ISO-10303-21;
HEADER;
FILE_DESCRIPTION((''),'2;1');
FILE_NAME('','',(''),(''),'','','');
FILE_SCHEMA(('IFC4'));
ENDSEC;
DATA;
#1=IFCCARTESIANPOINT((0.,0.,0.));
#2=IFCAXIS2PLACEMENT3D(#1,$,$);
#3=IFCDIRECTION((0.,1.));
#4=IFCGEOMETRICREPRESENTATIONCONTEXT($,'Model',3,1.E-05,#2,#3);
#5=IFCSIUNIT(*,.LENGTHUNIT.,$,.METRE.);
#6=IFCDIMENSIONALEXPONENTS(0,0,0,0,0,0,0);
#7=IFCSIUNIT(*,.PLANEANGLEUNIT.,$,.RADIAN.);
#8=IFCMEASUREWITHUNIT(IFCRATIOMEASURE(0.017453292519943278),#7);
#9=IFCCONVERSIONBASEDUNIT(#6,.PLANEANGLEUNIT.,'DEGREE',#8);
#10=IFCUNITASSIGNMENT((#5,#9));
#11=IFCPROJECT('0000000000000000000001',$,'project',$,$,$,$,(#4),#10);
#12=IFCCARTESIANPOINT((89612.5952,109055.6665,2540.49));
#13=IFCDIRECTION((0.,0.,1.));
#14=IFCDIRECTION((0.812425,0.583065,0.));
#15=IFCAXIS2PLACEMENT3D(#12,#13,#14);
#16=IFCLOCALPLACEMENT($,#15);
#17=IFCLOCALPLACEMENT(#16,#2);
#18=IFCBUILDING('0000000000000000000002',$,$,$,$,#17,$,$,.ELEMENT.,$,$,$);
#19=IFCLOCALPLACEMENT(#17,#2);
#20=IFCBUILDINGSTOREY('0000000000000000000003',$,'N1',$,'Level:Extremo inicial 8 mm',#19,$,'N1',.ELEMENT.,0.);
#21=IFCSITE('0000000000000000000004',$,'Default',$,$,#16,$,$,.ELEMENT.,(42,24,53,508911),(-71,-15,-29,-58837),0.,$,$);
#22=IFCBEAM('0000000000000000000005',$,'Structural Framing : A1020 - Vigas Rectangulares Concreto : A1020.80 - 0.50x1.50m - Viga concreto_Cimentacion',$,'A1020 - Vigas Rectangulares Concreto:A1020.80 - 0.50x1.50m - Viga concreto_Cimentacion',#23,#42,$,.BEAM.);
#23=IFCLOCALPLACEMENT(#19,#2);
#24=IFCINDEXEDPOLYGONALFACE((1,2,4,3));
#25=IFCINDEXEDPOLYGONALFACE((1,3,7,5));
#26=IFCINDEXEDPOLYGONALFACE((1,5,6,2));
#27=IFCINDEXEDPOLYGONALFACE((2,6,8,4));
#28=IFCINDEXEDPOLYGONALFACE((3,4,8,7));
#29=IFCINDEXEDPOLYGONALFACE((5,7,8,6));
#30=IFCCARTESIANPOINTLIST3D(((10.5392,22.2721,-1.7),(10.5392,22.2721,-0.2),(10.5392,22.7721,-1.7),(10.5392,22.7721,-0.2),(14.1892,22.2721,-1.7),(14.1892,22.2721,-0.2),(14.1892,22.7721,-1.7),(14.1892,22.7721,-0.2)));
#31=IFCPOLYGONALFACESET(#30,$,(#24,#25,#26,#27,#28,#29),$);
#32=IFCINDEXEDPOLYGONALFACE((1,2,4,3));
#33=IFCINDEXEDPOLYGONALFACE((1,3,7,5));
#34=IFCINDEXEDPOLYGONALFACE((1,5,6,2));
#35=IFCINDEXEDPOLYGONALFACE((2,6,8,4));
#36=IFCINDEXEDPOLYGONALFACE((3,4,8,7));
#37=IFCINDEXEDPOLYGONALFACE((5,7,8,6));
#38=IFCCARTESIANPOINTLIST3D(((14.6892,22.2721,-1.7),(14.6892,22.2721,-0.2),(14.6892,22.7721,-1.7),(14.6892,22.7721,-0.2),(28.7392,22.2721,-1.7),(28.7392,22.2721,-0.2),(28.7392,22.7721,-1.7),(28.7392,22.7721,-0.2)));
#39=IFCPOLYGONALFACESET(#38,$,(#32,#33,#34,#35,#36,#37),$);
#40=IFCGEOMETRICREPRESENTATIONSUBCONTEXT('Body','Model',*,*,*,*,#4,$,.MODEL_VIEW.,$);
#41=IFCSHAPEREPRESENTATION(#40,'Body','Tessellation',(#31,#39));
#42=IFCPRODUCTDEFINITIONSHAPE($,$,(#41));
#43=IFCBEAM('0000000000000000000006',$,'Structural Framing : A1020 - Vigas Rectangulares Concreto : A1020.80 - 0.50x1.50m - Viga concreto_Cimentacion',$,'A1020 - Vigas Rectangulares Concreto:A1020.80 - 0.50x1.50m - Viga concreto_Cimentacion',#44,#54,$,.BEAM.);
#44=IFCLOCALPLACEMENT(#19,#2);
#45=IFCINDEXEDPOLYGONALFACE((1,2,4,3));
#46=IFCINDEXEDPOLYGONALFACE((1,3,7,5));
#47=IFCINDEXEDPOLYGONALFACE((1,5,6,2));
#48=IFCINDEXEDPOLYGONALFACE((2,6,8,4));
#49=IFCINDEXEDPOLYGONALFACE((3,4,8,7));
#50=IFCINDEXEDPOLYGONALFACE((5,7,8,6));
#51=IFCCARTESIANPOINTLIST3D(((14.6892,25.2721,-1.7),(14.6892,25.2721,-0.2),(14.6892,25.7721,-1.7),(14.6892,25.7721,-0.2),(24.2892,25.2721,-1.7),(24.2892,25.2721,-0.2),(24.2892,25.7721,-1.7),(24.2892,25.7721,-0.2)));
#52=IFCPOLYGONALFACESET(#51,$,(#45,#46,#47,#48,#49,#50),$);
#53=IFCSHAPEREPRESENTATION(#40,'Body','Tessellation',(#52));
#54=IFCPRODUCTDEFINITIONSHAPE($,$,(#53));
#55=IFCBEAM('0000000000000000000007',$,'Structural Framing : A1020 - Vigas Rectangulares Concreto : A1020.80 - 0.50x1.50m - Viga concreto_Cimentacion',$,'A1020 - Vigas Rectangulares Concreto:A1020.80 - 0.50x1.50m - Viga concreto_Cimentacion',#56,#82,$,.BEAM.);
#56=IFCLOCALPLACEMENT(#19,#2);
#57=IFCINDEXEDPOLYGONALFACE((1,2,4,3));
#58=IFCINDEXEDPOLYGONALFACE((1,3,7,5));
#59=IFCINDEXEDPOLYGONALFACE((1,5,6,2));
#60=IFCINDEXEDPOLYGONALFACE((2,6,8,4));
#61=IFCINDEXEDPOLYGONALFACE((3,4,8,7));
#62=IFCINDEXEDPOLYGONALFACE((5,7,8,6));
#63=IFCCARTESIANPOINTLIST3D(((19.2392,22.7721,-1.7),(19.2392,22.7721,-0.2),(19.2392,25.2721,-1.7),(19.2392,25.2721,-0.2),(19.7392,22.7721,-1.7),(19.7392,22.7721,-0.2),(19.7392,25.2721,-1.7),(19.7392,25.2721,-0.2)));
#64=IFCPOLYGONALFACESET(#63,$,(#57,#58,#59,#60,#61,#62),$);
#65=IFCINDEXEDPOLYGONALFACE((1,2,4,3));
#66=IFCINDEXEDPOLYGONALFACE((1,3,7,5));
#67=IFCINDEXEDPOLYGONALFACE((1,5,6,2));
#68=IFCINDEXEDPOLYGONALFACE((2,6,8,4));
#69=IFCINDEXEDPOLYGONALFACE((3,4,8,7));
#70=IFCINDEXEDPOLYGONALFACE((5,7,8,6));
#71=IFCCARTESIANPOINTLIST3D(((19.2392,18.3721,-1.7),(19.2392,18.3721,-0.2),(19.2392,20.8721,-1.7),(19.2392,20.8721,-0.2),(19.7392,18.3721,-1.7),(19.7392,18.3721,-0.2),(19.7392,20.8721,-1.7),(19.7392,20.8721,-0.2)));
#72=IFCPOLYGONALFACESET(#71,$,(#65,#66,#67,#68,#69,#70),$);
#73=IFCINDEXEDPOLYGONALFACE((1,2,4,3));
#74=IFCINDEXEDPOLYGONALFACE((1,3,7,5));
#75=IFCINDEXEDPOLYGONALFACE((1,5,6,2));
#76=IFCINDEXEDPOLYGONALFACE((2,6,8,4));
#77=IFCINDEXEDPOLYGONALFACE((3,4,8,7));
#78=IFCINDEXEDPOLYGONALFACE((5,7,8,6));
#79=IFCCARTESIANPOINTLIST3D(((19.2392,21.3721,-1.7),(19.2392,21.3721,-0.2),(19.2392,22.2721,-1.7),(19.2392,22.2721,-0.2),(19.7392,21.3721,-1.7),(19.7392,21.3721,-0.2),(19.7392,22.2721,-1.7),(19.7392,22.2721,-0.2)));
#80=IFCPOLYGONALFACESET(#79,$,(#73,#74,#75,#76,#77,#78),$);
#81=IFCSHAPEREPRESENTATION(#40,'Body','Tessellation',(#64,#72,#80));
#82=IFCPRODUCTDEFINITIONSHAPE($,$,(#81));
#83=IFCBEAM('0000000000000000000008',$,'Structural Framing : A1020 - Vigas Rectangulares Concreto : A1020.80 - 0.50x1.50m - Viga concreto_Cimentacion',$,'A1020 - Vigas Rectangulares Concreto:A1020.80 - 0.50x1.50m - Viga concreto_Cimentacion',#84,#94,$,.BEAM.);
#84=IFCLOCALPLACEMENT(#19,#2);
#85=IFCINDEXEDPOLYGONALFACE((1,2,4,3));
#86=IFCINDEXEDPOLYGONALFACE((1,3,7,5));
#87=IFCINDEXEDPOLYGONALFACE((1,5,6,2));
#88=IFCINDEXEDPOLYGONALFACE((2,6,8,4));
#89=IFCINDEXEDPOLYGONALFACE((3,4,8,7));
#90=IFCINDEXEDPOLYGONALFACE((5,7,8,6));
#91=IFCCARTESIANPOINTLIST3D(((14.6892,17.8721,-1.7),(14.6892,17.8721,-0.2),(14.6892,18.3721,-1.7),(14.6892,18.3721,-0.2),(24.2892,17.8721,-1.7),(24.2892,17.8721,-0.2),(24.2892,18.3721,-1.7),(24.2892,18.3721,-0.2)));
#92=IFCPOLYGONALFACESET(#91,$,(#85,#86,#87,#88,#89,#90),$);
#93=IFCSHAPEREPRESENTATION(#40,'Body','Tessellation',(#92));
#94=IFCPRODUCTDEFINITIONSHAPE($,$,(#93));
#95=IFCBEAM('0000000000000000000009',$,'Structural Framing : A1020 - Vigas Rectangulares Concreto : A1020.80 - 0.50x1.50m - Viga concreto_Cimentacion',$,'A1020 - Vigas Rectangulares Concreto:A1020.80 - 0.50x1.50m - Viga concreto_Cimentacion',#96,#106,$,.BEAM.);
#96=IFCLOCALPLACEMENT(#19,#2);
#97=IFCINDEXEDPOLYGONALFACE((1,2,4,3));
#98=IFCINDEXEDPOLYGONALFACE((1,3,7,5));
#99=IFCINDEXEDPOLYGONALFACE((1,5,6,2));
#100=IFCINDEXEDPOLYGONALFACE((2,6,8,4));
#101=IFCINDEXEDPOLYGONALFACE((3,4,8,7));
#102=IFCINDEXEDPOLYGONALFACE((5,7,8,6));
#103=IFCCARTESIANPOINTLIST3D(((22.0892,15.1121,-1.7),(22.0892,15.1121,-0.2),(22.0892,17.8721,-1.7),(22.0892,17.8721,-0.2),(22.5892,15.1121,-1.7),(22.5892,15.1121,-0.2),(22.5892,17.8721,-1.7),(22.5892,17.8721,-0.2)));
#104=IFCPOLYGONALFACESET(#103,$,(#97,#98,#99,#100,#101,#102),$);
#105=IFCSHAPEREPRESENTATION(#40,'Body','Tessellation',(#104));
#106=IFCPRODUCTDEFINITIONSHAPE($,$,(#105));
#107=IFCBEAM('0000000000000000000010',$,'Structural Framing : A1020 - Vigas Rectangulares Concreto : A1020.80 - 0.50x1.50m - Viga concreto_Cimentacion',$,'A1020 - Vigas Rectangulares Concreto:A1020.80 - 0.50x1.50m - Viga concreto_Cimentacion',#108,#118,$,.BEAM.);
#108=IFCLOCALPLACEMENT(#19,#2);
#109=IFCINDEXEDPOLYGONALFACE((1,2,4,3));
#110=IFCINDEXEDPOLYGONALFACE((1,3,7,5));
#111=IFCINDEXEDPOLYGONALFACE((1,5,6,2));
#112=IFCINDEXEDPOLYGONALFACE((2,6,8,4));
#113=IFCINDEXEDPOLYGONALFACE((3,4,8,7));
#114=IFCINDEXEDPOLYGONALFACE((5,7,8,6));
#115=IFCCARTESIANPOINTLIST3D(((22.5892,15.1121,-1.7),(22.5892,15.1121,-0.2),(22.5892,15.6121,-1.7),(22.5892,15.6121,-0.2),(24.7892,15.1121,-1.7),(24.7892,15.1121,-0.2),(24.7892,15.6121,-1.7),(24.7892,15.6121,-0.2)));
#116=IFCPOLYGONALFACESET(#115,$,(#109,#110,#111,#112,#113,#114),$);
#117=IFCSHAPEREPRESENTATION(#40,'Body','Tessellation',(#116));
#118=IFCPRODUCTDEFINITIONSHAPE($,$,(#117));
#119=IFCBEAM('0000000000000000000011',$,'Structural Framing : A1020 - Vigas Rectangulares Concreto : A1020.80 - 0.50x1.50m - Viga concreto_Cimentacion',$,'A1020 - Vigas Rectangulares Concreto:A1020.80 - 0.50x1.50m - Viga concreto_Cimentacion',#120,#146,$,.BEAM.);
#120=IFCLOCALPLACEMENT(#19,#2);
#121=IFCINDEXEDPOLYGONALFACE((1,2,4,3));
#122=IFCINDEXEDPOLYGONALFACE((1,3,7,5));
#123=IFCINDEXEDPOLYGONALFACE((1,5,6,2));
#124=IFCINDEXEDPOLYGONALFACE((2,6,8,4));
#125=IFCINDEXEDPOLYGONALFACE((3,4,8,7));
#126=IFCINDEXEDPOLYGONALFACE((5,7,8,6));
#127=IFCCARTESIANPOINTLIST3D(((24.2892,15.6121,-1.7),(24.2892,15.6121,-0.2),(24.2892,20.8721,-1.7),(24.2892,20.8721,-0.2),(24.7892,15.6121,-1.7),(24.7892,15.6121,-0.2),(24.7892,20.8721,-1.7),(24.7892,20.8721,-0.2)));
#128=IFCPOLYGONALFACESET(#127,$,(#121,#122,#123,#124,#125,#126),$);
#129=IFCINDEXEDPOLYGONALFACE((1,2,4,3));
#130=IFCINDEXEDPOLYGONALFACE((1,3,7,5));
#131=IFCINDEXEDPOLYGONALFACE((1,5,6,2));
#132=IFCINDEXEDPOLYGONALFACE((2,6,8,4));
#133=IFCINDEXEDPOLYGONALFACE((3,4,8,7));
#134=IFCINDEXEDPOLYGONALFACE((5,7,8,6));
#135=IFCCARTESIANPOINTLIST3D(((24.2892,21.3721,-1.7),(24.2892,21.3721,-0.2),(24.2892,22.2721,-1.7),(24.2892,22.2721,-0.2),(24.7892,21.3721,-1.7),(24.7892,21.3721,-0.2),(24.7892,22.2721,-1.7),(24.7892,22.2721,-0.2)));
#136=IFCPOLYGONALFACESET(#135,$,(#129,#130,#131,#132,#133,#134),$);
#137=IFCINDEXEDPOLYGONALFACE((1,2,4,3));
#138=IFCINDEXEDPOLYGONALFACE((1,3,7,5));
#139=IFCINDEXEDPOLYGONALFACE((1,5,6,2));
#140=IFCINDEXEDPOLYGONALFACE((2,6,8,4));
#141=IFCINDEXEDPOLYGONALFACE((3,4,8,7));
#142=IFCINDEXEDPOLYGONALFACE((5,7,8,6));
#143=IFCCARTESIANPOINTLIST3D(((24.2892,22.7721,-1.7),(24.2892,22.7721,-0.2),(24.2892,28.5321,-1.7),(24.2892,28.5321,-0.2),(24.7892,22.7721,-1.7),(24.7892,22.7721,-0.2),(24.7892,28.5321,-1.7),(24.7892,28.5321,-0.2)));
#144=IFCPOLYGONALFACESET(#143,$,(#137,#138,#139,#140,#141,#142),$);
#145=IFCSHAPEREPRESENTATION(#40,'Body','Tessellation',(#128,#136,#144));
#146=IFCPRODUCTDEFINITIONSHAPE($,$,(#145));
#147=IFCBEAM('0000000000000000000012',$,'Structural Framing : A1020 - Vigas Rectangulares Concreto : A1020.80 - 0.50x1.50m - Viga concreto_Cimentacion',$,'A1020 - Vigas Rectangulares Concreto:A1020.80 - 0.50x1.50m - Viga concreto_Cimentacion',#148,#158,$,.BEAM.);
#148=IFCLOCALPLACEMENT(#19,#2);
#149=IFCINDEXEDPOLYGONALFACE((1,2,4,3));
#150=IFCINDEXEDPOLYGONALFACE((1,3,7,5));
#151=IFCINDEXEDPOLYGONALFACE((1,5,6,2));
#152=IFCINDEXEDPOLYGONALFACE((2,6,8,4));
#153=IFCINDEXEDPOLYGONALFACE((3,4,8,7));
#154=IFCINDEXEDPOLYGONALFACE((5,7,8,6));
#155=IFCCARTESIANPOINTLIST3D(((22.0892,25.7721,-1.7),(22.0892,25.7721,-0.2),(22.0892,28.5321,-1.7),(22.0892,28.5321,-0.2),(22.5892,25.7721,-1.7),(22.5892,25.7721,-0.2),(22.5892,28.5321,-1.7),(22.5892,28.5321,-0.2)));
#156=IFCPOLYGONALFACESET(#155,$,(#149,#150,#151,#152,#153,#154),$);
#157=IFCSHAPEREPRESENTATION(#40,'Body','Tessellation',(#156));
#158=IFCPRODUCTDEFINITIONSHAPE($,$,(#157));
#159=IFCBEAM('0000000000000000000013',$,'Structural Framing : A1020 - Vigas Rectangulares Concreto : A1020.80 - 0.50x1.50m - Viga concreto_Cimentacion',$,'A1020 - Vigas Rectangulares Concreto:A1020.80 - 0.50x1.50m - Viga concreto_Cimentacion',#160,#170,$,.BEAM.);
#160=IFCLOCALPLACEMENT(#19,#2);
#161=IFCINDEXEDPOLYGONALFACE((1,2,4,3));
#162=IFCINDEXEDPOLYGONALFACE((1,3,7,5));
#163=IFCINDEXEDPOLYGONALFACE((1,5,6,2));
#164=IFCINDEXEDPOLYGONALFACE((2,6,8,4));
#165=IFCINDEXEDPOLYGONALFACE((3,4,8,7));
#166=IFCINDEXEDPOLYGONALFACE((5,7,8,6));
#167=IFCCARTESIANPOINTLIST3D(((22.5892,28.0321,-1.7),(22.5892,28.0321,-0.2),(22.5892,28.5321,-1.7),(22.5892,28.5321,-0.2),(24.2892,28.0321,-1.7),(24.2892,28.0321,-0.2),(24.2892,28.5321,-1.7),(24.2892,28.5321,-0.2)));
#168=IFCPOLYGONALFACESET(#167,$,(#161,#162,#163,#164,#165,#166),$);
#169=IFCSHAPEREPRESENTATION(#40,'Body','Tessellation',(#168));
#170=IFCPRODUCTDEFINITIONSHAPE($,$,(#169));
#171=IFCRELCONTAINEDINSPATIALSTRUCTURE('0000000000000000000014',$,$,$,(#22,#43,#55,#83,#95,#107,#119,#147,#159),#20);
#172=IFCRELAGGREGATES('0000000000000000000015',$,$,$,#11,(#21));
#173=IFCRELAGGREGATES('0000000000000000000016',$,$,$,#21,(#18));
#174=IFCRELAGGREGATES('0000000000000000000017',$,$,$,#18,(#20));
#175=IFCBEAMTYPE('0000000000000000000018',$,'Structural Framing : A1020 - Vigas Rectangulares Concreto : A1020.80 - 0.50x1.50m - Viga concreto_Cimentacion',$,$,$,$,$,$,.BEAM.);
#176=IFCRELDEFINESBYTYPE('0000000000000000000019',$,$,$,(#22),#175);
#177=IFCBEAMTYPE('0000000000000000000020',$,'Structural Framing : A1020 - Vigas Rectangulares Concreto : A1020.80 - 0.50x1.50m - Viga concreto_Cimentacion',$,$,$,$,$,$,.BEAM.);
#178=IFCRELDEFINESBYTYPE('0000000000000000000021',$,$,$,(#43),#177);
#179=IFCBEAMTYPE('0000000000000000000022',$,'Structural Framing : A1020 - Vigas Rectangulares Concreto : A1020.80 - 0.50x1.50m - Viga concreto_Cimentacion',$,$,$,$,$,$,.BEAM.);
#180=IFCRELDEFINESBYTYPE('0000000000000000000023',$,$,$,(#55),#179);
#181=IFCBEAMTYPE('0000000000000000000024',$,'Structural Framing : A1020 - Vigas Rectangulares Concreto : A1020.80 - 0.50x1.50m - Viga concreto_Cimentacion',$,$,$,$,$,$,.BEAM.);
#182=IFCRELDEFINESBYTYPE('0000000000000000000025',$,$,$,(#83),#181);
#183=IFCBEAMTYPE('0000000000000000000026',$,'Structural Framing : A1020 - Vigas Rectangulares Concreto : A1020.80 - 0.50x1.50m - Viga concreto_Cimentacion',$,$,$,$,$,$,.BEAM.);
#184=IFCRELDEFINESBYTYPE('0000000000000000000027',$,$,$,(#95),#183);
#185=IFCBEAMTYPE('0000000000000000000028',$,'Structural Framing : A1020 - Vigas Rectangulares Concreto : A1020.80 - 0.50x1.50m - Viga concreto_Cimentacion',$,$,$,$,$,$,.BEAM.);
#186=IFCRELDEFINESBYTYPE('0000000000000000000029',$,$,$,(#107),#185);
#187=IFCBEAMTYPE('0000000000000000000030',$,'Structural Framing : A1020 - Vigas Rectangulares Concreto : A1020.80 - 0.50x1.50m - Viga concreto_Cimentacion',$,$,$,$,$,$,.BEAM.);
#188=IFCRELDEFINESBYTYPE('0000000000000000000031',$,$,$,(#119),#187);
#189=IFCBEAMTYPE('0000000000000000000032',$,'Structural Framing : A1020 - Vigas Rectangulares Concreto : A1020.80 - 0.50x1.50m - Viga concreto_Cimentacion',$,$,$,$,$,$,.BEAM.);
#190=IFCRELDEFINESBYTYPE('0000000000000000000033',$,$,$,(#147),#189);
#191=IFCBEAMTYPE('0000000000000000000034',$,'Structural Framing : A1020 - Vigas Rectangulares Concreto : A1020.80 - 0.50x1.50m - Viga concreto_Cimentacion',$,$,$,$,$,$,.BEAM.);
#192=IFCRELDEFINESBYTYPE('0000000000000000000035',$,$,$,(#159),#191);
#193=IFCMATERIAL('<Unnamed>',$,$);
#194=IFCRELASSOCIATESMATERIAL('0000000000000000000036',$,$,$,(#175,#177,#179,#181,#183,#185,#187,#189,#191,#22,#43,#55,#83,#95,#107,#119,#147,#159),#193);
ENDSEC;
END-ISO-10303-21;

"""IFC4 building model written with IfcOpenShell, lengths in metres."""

from ifc_helpers import new_model, entity, si_unit, converted_unit, direction, frame, frame_2d, origin, place, context, subcontext, project, spatial, polyline, segment, composite_curve, rectangle, outline, extrude, source, transform, mapped, material, material_profile, profile_set, profile_usage, type_object, type_shapes, element, save


model = new_model("IFC4")

# Units and contexts
model_context = context("Model", 3, precision=1e-05, world=origin(), true_north=direction((0.0, 1.0)))
body_context = subcontext(model_context, "Body", "Model", "MODEL_VIEW")
ifc_project = project(units=[si_unit("LENGTHUNIT", "METRE"), converted_unit("PLANEANGLEUNIT", "DEGREE", entity("IfcRatioMeasure", 0.017453292519943278), si_unit("PLANEANGLEUNIT", "RADIAN"), dimensions=[0, 0, 0, 0, 0, 0, 0])], contexts=[model_context])

# Site, building, storey
site_placement = place(None, frame((89612.5952, 109055.6665, 2540.49), z_axis=(0.0, 0.0, 1.0), x_axis=(0.812425, 0.583065, 0.0)))
site = spatial("IfcSite", under=ifc_project, at=site_placement, Name="Default", CompositionType="ELEMENT", RefLatitude=(42, 24, 53, 508911), RefLongitude=(-71, -15, -29, -58837), RefElevation=0.0)
building_placement = place(site_placement, origin())
building = spatial("IfcBuilding", under=site, at=building_placement, CompositionType="ELEMENT")
storey_placement = place(building_placement, origin())
storey = spatial("IfcBuildingStorey", under=building, at=storey_placement, Name="N1", ObjectType="Level:Extremo inicial 8 mm", LongName="N1", CompositionType="ELEMENT", Elevation=0.0)

# Beams
ifc_material_1 = material(Name="<Unnamed>")
ifc_material_profile_1 = material_profile(ifc_material_1, outline(composite_curve([segment(polyline([(-0.25, -0.75, 0.0), (-0.25, 0.75, 0.0)]), True, "CONTINUOUS"), segment(polyline([(-0.25, 0.75, 0.0), (0.25, 0.75, 0.0)]), True, "CONTINUOUS"), segment(polyline([(0.25, 0.75, 0.0), (0.25, -0.75, 0.0)]), True, "CONTINUOUS"), segment(polyline([(0.25, -0.75, 0.0), (-0.25, -0.75, 0.0)]), True, "CONTINUOUS")], self_intersect=False), kind="CURVE"), Name="A1020.80 - 0.50x1.50m - Viga concreto_Cimentacion")
ifc_material_profile_2 = material_profile(ifc_material_1, outline(composite_curve([segment(polyline([(6.1973, 0.25, 0.75), (6.1973, 0.25, -0.75)]), True, "CONTINUOUS"), segment(polyline([(6.1973, 0.25, -0.75), (-6.1973, 0.25, -0.75)]), True, "CONTINUOUS"), segment(polyline([(-6.1973, 0.25, -0.75), (-6.1973, 0.25, 0.75)]), True, "CONTINUOUS"), segment(polyline([(-6.1973, 0.25, 0.75), (6.1973, 0.25, 0.75)]), True, "CONTINUOUS")], self_intersect=False), kind="CURVE"), Name="A1020.80 - 0.50x1.50m - Viga concreto_Cimentacion")
ifc_profile_set_1 = profile_set([ifc_material_profile_1, ifc_material_profile_2], Name="A1020.80 - 0.50x1.50m - Viga concreto_Cimentacion")
ifc_profile_usage_1 = profile_usage(ifc_profile_set_1, cardinal=8)
beam_type_1 = type_object("IfcBeamType", Name="Structural Framing : A1020 - Vigas Rectangulares Concreto : A1020.80 - 0.50x1.50m - Viga concreto_Cimentacion", PredefinedType="BEAM", material=ifc_profile_set_1)
shared_shape_1 = source(origin(), body_context, "Body", "SweptSolid", [
    extrude(rectangle(XDim=1.5, YDim=0.5, at=frame_2d((0.0, 0.0), x_axis=(1.0, 0.0))), frame((10.5392, 22.5221, -0.95), z_axis=(1.0, 0.0, 0.0), x_axis=(0.0, 0.0, -1.0)), (0.0, 0.0, 1.0), 3.65),
    extrude(rectangle(XDim=1.5, YDim=0.5, at=frame_2d((0.0, 0.0), x_axis=(1.0, 0.0))), frame((14.6892, 22.5221, -0.95), z_axis=(1.0, 0.0, 0.0), x_axis=(0.0, 0.0, -1.0)), (0.0, 0.0, 1.0), 14.05),
])
type_shapes(beam_type_1, [shared_shape_1])
beam_1_placement = place(storey_placement, origin())
element("IfcBeam", 1, at=beam_1_placement, inside=storey, type_object=beam_type_1, material=ifc_profile_usage_1, Name="Structural Framing : A1020 - Vigas Rectangulares Concreto : A1020.80 - 0.50x1.50m - Viga concreto_Cimentacion", ObjectType="A1020 - Vigas Rectangulares Concreto:A1020.80 - 0.50x1.50m - Viga concreto_Cimentacion", PredefinedType="BEAM", context=body_context, shape_type="MappedRepresentation", body=[
    mapped(shared_shape_1, transform((0.0, 0.0, 0.0), scale=1.0)),
])
ifc_profile_usage_2 = profile_usage(ifc_profile_set_1, cardinal=8)
beam_type_2 = type_object("IfcBeamType", Name="Structural Framing : A1020 - Vigas Rectangulares Concreto : A1020.80 - 0.50x1.50m - Viga concreto_Cimentacion", PredefinedType="BEAM", material=ifc_profile_set_1)
shared_shape_2 = source(origin(), body_context, "Body", "SweptSolid", [
    extrude(rectangle(XDim=1.5, YDim=0.5, at=frame_2d((0.0, 0.0), x_axis=(1.0, 0.0))), frame((14.6892, 25.5221, -0.95), z_axis=(1.0, 0.0, 0.0), x_axis=(0.0, 0.0, -1.0)), (0.0, 0.0, 1.0), 9.6),
])
type_shapes(beam_type_2, [shared_shape_2])
beam_2_placement = place(storey_placement, origin())
element("IfcBeam", 2, at=beam_2_placement, inside=storey, type_object=beam_type_2, material=ifc_profile_usage_2, Name="Structural Framing : A1020 - Vigas Rectangulares Concreto : A1020.80 - 0.50x1.50m - Viga concreto_Cimentacion", ObjectType="A1020 - Vigas Rectangulares Concreto:A1020.80 - 0.50x1.50m - Viga concreto_Cimentacion", PredefinedType="BEAM", context=body_context, shape_type="MappedRepresentation", body=[
    mapped(shared_shape_2, transform((0.0, 0.0, 0.0), scale=1.0)),
])
ifc_profile_usage_3 = profile_usage(ifc_profile_set_1, cardinal=8)
beam_type_3 = type_object("IfcBeamType", Name="Structural Framing : A1020 - Vigas Rectangulares Concreto : A1020.80 - 0.50x1.50m - Viga concreto_Cimentacion", PredefinedType="BEAM", material=ifc_profile_set_1)
shared_shape_3 = source(origin(), body_context, "Body", "SweptSolid", [
    extrude(rectangle(XDim=1.5, YDim=0.5, at=frame_2d((0.0, 0.0), x_axis=(0.0, 1.0))), frame((19.4892, 25.2721, -0.95), z_axis=(0.0, -1.0, 0.0), x_axis=(-1.0, 0.0, 0.0)), (0.0, 0.0, 1.0), 2.5),
    extrude(rectangle(XDim=1.5, YDim=0.5, at=frame_2d((0.0, 0.0), x_axis=(0.0, 1.0))), frame((19.4892, 20.8721, -0.95), z_axis=(0.0, -1.0, 0.0), x_axis=(-1.0, 0.0, 0.0)), (0.0, 0.0, 1.0), 2.5),
    extrude(rectangle(XDim=1.5, YDim=0.5, at=frame_2d((0.0, 0.0), x_axis=(0.0, 1.0))), frame((19.4892, 22.2721, -0.95), z_axis=(0.0, -1.0, 0.0), x_axis=(-1.0, 0.0, 0.0)), (0.0, 0.0, 1.0), 0.9),
])
type_shapes(beam_type_3, [shared_shape_3])
beam_3_placement = place(storey_placement, origin())
element("IfcBeam", 3, at=beam_3_placement, inside=storey, type_object=beam_type_3, material=ifc_profile_usage_3, Name="Structural Framing : A1020 - Vigas Rectangulares Concreto : A1020.80 - 0.50x1.50m - Viga concreto_Cimentacion", ObjectType="A1020 - Vigas Rectangulares Concreto:A1020.80 - 0.50x1.50m - Viga concreto_Cimentacion", PredefinedType="BEAM", context=body_context, shape_type="MappedRepresentation", body=[
    mapped(shared_shape_3, transform((0.0, 0.0, 0.0), scale=1.0)),
])
ifc_profile_usage_4 = profile_usage(ifc_profile_set_1, cardinal=8)
beam_type_4 = type_object("IfcBeamType", Name="Structural Framing : A1020 - Vigas Rectangulares Concreto : A1020.80 - 0.50x1.50m - Viga concreto_Cimentacion", PredefinedType="BEAM", material=ifc_profile_set_1)
shared_shape_4 = source(origin(), body_context, "Body", "SweptSolid", [
    extrude(rectangle(XDim=1.5, YDim=0.5, at=frame_2d((0.0, 0.0), x_axis=(1.0, 0.0))), frame((14.6892, 18.1221, -0.95), z_axis=(1.0, 0.0, 0.0), x_axis=(0.0, 0.0, -1.0)), (0.0, 0.0, 1.0), 9.6),
])
type_shapes(beam_type_4, [shared_shape_4])
beam_4_placement = place(storey_placement, origin())
element("IfcBeam", 4, at=beam_4_placement, inside=storey, type_object=beam_type_4, material=ifc_profile_usage_4, Name="Structural Framing : A1020 - Vigas Rectangulares Concreto : A1020.80 - 0.50x1.50m - Viga concreto_Cimentacion", ObjectType="A1020 - Vigas Rectangulares Concreto:A1020.80 - 0.50x1.50m - Viga concreto_Cimentacion", PredefinedType="BEAM", context=body_context, shape_type="MappedRepresentation", body=[
    mapped(shared_shape_4, transform((0.0, 0.0, 0.0), scale=1.0)),
])
ifc_profile_usage_5 = profile_usage(ifc_profile_set_1, cardinal=8)
beam_type_5 = type_object("IfcBeamType", Name="Structural Framing : A1020 - Vigas Rectangulares Concreto : A1020.80 - 0.50x1.50m - Viga concreto_Cimentacion", PredefinedType="BEAM", material=ifc_profile_set_1)
shared_shape_5 = source(origin(), body_context, "Body", "SweptSolid", [
    extrude(rectangle(XDim=1.5, YDim=0.5, at=frame_2d((0.0, 0.0), x_axis=(0.0, 1.0))), frame((22.3392, 17.8721, -0.95), z_axis=(0.0, -1.0, 0.0), x_axis=(-1.0, 0.0, 0.0)), (0.0, 0.0, 1.0), 2.76),
])
type_shapes(beam_type_5, [shared_shape_5])
beam_5_placement = place(storey_placement, origin())
element("IfcBeam", 5, at=beam_5_placement, inside=storey, type_object=beam_type_5, material=ifc_profile_usage_5, Name="Structural Framing : A1020 - Vigas Rectangulares Concreto : A1020.80 - 0.50x1.50m - Viga concreto_Cimentacion", ObjectType="A1020 - Vigas Rectangulares Concreto:A1020.80 - 0.50x1.50m - Viga concreto_Cimentacion", PredefinedType="BEAM", context=body_context, shape_type="MappedRepresentation", body=[
    mapped(shared_shape_5, transform((0.0, 0.0, 0.0), scale=1.0)),
])
ifc_profile_usage_6 = profile_usage(ifc_profile_set_1, cardinal=8)
beam_type_6 = type_object("IfcBeamType", Name="Structural Framing : A1020 - Vigas Rectangulares Concreto : A1020.80 - 0.50x1.50m - Viga concreto_Cimentacion", PredefinedType="BEAM", material=ifc_profile_set_1)
shared_shape_6 = source(origin(), body_context, "Body", "SweptSolid", [
    extrude(rectangle(XDim=1.5, YDim=0.5, at=frame_2d((0.0, 0.0), x_axis=(1.0, 0.0))), frame((22.5892, 15.3621, -0.95), z_axis=(1.0, 0.0, 0.0), x_axis=(0.0, 0.0, -1.0)), (0.0, 0.0, 1.0), 2.2),
])
type_shapes(beam_type_6, [shared_shape_6])
beam_6_placement = place(storey_placement, origin())
element("IfcBeam", 6, at=beam_6_placement, inside=storey, type_object=beam_type_6, material=ifc_profile_usage_6, Name="Structural Framing : A1020 - Vigas Rectangulares Concreto : A1020.80 - 0.50x1.50m - Viga concreto_Cimentacion", ObjectType="A1020 - Vigas Rectangulares Concreto:A1020.80 - 0.50x1.50m - Viga concreto_Cimentacion", PredefinedType="BEAM", context=body_context, shape_type="MappedRepresentation", body=[
    mapped(shared_shape_6, transform((0.0, 0.0, 0.0), scale=1.0)),
])
ifc_profile_usage_7 = profile_usage(ifc_profile_set_1, cardinal=8)
beam_type_7 = type_object("IfcBeamType", Name="Structural Framing : A1020 - Vigas Rectangulares Concreto : A1020.80 - 0.50x1.50m - Viga concreto_Cimentacion", PredefinedType="BEAM", material=ifc_profile_set_1)
shared_shape_7 = source(origin(), body_context, "Body", "SweptSolid", [
    extrude(rectangle(XDim=1.5, YDim=0.5, at=frame_2d((0.0, 0.0), x_axis=(0.0, 1.0))), frame((24.5392, 15.6121, -0.95), z_axis=(0.0, 1.0, 0.0), x_axis=(-1.0, 0.0, 0.0)), (0.0, 0.0, 1.0), 5.26),
    extrude(rectangle(XDim=1.5, YDim=0.5, at=frame_2d((0.0, 0.0), x_axis=(0.0, 1.0))), frame((24.5392, 21.3721, -0.95), z_axis=(0.0, 1.0, 0.0), x_axis=(-1.0, 0.0, 0.0)), (0.0, 0.0, 1.0), 0.9),
    extrude(rectangle(XDim=1.5, YDim=0.5, at=frame_2d((0.0, 0.0), x_axis=(0.0, 1.0))), frame((24.5392, 22.7721, -0.95), z_axis=(0.0, 1.0, 0.0), x_axis=(-1.0, 0.0, 0.0)), (0.0, 0.0, 1.0), 5.76),
])
type_shapes(beam_type_7, [shared_shape_7])
beam_7_placement = place(storey_placement, origin())
element("IfcBeam", 7, at=beam_7_placement, inside=storey, type_object=beam_type_7, material=ifc_profile_usage_7, Name="Structural Framing : A1020 - Vigas Rectangulares Concreto : A1020.80 - 0.50x1.50m - Viga concreto_Cimentacion", ObjectType="A1020 - Vigas Rectangulares Concreto:A1020.80 - 0.50x1.50m - Viga concreto_Cimentacion", PredefinedType="BEAM", context=body_context, shape_type="MappedRepresentation", body=[
    mapped(shared_shape_7, transform((0.0, 0.0, 0.0), scale=1.0)),
])
ifc_profile_usage_8 = profile_usage(ifc_profile_set_1, cardinal=8)
beam_type_8 = type_object("IfcBeamType", Name="Structural Framing : A1020 - Vigas Rectangulares Concreto : A1020.80 - 0.50x1.50m - Viga concreto_Cimentacion", PredefinedType="BEAM", material=ifc_profile_set_1)
shared_shape_8 = source(origin(), body_context, "Body", "SweptSolid", [
    extrude(rectangle(XDim=1.5, YDim=0.5, at=frame_2d((0.0, 0.0), x_axis=(0.0, 1.0))), frame((22.3392, 25.7721, -0.95), z_axis=(0.0, 1.0, 0.0), x_axis=(-1.0, 0.0, 0.0)), (0.0, 0.0, 1.0), 2.76),
])
type_shapes(beam_type_8, [shared_shape_8])
beam_8_placement = place(storey_placement, origin())
element("IfcBeam", 8, at=beam_8_placement, inside=storey, type_object=beam_type_8, material=ifc_profile_usage_8, Name="Structural Framing : A1020 - Vigas Rectangulares Concreto : A1020.80 - 0.50x1.50m - Viga concreto_Cimentacion", ObjectType="A1020 - Vigas Rectangulares Concreto:A1020.80 - 0.50x1.50m - Viga concreto_Cimentacion", PredefinedType="BEAM", context=body_context, shape_type="MappedRepresentation", body=[
    mapped(shared_shape_8, transform((0.0, 0.0, 0.0), scale=1.0)),
])
ifc_profile_usage_9 = profile_usage(ifc_profile_set_1, cardinal=8)
beam_type_9 = type_object("IfcBeamType", Name="Structural Framing : A1020 - Vigas Rectangulares Concreto : A1020.80 - 0.50x1.50m - Viga concreto_Cimentacion", PredefinedType="BEAM", material=ifc_profile_set_1)
shared_shape_9 = source(origin(), body_context, "Body", "SweptSolid", [
    extrude(rectangle(XDim=1.5, YDim=0.5, at=frame_2d((0.0, 0.0), x_axis=(1.0, 0.0))), frame((24.2892, 28.2821, -0.95), z_axis=(-1.0, 0.0, 0.0), x_axis=(0.0, 0.0, -1.0)), (0.0, 0.0, 1.0), 1.7),
])
type_shapes(beam_type_9, [shared_shape_9])
beam_9_placement = place(storey_placement, origin())
element("IfcBeam", 9, at=beam_9_placement, inside=storey, type_object=beam_type_9, material=ifc_profile_usage_9, Name="Structural Framing : A1020 - Vigas Rectangulares Concreto : A1020.80 - 0.50x1.50m - Viga concreto_Cimentacion", ObjectType="A1020 - Vigas Rectangulares Concreto:A1020.80 - 0.50x1.50m - Viga concreto_Cimentacion", PredefinedType="BEAM", context=body_context, shape_type="MappedRepresentation", body=[
    mapped(shared_shape_9, transform((0.0, 0.0, 0.0), scale=1.0)),
])

save(model, "model.ifc")
